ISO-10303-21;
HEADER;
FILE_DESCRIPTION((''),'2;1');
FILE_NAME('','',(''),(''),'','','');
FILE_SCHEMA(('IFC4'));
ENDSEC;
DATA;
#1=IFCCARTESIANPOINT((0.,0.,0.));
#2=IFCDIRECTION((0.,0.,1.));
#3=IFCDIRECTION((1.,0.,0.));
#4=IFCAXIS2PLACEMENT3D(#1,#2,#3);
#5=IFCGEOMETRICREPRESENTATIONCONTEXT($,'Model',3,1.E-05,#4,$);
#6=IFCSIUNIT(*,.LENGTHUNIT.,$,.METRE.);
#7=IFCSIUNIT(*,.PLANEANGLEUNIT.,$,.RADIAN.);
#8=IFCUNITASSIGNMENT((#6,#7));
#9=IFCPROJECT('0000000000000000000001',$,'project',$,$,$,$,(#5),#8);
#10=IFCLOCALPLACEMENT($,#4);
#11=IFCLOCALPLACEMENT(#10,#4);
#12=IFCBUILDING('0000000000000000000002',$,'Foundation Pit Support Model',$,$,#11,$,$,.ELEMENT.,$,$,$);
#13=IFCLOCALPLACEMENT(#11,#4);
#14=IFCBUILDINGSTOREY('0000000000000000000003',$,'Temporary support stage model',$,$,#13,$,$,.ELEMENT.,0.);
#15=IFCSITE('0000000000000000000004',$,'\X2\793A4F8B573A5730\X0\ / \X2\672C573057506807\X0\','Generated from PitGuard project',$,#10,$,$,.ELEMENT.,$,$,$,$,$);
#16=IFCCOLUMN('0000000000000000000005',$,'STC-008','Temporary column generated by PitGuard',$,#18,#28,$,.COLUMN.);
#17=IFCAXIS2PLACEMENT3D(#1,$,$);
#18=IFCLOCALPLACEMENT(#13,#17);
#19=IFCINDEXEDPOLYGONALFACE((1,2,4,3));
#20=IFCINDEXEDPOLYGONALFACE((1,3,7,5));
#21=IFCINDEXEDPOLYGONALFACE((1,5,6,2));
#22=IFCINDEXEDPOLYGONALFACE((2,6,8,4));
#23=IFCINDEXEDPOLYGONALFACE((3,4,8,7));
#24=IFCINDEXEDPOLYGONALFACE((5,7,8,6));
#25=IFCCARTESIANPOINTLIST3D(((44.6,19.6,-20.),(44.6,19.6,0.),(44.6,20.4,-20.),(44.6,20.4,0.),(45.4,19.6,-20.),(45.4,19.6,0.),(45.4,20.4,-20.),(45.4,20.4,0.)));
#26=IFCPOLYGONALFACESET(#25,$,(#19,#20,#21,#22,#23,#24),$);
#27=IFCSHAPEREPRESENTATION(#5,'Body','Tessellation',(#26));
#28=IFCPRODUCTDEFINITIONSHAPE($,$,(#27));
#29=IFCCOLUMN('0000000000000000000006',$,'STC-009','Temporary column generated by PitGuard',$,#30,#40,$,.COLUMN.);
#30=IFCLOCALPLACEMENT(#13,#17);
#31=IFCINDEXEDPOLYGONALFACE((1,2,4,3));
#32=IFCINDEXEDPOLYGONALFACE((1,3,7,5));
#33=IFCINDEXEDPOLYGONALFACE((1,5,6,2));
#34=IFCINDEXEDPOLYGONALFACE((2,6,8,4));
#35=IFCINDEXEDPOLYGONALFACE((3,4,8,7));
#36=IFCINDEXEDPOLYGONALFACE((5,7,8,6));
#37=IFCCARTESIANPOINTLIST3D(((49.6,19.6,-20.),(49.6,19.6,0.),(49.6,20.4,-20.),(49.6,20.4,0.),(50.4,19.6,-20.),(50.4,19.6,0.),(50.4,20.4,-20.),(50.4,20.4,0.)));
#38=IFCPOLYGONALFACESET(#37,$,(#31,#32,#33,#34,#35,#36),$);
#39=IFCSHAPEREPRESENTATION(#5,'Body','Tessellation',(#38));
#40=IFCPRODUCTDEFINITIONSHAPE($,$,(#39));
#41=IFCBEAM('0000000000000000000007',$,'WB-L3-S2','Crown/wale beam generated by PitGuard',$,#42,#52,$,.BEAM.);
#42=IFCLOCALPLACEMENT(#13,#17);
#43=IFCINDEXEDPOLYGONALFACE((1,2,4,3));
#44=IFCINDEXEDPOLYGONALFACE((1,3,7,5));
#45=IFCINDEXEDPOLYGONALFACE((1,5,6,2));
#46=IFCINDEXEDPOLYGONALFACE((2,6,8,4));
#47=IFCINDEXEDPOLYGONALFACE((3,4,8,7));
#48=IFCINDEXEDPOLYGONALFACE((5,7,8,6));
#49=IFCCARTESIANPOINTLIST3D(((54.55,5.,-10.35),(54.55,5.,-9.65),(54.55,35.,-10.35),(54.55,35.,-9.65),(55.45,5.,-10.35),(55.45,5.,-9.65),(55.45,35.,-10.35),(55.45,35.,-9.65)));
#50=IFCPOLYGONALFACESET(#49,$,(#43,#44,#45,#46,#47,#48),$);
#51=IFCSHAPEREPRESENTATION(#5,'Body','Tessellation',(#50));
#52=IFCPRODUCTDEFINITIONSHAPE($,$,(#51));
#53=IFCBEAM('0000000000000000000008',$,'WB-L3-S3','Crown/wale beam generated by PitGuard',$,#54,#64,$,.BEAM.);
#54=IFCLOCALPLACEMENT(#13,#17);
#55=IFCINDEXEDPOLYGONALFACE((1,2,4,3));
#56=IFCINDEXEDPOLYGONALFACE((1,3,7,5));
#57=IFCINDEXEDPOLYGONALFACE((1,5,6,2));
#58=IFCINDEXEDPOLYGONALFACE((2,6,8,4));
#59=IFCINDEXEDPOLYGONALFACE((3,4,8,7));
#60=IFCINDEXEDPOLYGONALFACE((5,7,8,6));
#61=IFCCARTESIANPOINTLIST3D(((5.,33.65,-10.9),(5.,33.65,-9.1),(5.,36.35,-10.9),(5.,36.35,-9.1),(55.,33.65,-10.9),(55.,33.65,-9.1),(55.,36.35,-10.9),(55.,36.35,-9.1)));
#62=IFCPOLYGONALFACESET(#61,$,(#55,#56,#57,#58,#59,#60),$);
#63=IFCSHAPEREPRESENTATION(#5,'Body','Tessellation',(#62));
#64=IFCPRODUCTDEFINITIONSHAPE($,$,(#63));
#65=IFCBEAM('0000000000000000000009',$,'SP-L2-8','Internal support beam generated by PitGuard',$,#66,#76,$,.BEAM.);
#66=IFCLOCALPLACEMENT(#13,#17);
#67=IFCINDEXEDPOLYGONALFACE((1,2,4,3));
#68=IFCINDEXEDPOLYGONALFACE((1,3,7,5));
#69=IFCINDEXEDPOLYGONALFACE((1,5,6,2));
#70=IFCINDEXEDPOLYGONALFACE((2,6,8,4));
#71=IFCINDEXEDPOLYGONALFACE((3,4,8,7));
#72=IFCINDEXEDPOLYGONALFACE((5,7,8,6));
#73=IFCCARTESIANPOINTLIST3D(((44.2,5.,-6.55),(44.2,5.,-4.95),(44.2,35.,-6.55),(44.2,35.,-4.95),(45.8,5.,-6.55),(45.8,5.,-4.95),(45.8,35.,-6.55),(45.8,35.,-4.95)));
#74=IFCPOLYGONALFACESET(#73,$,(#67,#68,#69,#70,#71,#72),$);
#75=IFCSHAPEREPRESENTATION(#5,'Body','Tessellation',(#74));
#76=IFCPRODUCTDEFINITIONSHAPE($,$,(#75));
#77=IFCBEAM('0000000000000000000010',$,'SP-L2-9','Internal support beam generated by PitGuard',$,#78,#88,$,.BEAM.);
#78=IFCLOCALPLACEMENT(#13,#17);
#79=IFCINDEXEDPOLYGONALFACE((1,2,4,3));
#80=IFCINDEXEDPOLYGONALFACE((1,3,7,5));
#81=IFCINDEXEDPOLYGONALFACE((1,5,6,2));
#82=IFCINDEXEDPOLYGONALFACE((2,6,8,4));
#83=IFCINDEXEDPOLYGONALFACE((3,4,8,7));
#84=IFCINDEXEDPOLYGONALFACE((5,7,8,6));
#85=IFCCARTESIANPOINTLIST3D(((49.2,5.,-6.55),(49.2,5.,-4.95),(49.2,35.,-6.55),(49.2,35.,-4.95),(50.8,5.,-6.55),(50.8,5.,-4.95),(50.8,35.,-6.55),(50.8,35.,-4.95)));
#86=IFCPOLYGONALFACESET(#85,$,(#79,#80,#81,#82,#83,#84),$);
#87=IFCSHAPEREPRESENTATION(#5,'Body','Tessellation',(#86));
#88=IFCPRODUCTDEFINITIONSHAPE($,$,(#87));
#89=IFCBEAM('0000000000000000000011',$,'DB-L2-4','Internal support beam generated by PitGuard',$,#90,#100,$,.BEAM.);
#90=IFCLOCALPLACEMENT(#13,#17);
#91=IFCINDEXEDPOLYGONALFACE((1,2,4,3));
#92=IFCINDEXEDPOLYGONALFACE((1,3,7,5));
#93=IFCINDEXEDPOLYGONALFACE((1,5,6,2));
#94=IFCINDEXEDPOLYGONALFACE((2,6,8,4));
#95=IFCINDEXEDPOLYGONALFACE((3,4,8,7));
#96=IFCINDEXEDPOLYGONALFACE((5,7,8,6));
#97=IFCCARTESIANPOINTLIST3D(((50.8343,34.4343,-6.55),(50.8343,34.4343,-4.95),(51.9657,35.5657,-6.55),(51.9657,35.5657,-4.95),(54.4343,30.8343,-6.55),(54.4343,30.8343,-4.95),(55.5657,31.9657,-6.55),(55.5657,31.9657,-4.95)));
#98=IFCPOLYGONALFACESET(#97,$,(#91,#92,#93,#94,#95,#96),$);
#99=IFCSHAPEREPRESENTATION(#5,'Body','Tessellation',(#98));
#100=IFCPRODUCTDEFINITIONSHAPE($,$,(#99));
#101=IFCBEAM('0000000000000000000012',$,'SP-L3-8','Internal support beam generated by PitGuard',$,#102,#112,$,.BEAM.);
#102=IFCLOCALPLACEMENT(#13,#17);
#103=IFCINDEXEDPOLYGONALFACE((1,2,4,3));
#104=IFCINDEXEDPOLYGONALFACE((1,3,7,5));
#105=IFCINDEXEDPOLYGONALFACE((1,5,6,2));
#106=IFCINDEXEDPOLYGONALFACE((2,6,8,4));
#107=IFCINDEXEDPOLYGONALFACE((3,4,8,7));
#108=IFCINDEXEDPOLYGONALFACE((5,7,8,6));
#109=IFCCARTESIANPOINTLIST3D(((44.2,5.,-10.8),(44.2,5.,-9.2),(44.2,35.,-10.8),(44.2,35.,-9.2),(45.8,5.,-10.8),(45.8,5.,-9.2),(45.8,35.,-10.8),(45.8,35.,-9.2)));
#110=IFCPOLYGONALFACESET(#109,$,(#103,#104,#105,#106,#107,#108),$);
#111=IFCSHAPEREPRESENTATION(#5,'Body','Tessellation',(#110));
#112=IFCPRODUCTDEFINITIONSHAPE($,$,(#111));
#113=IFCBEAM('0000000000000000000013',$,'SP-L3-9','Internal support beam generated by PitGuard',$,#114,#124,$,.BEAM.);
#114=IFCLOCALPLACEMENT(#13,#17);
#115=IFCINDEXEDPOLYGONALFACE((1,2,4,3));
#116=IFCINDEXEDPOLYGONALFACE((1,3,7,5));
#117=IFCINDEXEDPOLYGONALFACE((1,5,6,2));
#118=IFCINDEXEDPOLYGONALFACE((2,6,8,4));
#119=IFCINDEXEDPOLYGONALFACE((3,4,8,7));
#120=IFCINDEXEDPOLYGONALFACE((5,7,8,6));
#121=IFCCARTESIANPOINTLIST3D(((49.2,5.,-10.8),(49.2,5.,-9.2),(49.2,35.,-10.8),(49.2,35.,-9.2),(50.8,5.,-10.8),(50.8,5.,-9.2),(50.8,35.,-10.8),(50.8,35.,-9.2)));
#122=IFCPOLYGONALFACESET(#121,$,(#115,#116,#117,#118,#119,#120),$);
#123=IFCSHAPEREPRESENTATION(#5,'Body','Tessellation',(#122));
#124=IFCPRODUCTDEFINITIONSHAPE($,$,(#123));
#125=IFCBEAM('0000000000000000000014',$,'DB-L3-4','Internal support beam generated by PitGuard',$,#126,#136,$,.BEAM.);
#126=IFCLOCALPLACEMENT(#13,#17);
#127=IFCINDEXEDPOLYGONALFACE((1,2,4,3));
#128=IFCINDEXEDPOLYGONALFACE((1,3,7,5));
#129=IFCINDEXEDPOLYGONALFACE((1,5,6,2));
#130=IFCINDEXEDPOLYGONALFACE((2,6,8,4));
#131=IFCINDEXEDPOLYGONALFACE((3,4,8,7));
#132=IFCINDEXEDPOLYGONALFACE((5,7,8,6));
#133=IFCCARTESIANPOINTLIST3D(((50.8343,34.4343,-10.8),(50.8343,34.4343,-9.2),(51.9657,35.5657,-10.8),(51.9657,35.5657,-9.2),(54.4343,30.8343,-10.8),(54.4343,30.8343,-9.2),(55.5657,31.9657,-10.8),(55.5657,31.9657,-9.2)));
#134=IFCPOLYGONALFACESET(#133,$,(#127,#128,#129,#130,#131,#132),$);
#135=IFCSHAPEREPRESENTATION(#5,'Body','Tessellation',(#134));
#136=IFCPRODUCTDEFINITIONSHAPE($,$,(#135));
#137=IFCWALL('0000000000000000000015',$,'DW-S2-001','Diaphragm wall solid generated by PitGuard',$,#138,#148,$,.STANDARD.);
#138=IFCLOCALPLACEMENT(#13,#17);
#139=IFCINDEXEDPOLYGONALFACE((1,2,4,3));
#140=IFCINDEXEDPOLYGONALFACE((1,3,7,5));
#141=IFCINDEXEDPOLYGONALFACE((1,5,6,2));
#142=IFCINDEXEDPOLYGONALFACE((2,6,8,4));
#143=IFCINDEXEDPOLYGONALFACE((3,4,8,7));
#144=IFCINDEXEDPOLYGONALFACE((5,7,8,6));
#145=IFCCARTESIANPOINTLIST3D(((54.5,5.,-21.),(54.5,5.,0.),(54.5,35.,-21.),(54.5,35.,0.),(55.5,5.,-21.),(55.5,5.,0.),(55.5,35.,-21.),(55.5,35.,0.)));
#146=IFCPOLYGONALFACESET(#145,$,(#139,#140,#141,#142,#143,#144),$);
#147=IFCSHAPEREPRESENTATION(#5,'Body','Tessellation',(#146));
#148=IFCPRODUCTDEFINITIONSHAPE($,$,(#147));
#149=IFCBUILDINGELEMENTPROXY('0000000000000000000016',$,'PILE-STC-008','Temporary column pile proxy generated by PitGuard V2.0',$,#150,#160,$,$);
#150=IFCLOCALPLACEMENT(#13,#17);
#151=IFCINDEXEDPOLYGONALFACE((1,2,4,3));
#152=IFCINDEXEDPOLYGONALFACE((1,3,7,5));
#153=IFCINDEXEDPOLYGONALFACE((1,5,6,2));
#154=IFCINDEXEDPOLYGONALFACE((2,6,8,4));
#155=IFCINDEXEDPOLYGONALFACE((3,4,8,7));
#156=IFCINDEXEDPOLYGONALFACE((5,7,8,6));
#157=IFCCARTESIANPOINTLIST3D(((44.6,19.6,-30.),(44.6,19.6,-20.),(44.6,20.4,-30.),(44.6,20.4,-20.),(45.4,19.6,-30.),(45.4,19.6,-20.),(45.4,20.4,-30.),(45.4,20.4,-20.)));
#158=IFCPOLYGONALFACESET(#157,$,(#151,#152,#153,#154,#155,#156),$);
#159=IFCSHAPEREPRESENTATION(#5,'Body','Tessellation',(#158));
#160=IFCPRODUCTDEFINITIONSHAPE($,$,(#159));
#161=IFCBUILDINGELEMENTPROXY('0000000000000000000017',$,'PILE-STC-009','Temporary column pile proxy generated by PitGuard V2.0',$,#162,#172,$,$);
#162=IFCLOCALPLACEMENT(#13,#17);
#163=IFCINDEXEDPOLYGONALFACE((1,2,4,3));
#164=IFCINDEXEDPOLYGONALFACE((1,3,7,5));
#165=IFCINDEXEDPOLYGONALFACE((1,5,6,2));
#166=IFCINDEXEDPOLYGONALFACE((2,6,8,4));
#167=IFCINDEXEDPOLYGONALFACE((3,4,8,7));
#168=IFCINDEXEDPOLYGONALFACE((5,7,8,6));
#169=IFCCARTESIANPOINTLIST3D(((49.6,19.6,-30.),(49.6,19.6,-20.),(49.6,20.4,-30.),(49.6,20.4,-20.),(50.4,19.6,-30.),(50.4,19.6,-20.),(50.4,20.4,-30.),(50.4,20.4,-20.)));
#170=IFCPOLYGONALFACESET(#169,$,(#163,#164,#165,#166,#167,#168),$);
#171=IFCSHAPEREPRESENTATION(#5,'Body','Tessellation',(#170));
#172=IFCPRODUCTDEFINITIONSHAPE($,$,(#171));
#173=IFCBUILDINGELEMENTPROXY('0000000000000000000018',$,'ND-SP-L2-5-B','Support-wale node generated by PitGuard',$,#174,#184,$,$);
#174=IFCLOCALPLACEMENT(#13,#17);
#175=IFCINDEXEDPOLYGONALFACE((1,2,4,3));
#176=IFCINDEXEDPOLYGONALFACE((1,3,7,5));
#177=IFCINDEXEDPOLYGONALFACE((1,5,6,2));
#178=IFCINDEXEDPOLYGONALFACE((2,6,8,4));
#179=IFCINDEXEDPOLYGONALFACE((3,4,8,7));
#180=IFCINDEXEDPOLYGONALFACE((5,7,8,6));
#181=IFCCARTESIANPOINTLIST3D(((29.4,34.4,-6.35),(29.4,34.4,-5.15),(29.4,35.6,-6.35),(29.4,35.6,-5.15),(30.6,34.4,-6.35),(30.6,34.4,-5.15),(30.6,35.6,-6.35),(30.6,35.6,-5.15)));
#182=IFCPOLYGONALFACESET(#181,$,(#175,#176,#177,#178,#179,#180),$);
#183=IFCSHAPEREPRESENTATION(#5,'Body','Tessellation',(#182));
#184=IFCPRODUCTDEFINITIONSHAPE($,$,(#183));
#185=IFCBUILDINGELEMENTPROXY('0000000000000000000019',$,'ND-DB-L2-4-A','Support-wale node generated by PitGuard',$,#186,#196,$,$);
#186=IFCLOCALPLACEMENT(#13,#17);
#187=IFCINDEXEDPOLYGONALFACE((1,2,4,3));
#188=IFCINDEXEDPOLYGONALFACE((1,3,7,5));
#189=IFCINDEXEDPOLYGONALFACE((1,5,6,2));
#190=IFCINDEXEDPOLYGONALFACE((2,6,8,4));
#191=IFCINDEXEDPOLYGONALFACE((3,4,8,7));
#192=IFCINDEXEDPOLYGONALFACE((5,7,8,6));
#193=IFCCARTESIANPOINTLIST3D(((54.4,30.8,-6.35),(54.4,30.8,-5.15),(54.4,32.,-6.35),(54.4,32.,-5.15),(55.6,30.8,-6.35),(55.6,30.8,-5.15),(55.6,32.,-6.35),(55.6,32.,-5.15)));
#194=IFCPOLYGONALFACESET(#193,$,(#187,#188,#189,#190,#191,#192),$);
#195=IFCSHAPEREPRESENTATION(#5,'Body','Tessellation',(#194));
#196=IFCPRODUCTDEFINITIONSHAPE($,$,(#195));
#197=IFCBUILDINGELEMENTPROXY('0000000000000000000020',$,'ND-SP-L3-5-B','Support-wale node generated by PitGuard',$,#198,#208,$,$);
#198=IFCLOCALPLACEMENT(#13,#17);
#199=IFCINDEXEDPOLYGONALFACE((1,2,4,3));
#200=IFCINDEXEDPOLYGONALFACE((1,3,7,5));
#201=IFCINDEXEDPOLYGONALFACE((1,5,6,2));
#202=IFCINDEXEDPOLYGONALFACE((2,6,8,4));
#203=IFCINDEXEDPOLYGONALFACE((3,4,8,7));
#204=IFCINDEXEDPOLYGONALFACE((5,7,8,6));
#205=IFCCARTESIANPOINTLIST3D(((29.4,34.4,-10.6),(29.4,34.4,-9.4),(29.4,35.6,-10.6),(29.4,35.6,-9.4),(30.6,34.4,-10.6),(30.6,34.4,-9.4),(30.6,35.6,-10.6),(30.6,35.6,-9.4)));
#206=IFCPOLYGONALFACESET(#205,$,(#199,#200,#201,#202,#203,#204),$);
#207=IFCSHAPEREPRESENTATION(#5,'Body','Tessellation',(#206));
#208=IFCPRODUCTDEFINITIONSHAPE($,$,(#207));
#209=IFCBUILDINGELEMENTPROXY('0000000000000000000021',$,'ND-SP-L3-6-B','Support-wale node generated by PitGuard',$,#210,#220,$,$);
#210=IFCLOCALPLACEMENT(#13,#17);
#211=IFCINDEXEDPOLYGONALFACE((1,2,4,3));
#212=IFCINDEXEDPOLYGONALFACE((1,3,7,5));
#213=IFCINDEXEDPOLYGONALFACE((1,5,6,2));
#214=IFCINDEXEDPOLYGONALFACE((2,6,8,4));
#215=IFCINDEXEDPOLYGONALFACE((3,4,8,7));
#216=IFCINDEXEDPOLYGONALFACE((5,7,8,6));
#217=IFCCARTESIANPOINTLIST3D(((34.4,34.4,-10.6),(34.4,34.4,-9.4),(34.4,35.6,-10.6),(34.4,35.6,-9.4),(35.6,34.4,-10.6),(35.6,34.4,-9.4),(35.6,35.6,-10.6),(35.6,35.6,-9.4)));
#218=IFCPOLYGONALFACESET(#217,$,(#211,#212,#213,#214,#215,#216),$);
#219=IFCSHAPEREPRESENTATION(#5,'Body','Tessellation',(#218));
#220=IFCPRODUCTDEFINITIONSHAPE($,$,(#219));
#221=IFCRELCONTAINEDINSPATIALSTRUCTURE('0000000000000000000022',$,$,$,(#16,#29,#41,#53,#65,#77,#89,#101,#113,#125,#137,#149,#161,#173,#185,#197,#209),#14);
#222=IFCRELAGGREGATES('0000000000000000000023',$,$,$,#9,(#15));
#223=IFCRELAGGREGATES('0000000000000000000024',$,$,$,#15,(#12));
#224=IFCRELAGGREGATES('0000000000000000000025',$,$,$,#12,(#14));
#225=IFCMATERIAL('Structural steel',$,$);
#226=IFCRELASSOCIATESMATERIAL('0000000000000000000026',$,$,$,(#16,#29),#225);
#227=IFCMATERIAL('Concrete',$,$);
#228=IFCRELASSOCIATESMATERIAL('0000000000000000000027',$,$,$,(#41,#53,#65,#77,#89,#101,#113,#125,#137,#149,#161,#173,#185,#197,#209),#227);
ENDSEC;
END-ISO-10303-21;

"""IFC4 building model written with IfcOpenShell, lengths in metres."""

from ifc_helpers import new_model, si_unit, frame, origin_with_axes, origin_2d, place, context, project, spatial, rectangle, extrude, material, element, save


model = new_model("IFC4")

# Units and contexts
model_context = context("Model", 3, precision=1e-05, world=origin_with_axes())
ifc_project = project(units=[si_unit("LENGTHUNIT", "METRE"), si_unit("PLANEANGLEUNIT", "RADIAN")], contexts=[model_context])

# Site, building, storey
site_placement = place(None, origin_with_axes())
site = spatial("IfcSite", under=ifc_project, at=site_placement, Name="示例场地 / 本地坐标", Description="Generated from PitGuard project", CompositionType="ELEMENT")
building_placement = place(site_placement, origin_with_axes())
building = spatial("IfcBuilding", under=site, at=building_placement, Name="Foundation Pit Support Model", CompositionType="ELEMENT")
storey_placement = place(building_placement, origin_with_axes())
storey = spatial("IfcBuildingStorey", under=building, at=storey_placement, Name="Temporary support stage model", CompositionType="ELEMENT", Elevation=0.0)

# Columns
ifc_material_1 = material(Name="Structural steel")
for number, where, z_axis, x_axis, name in (
    (1, (45.0, 20.0, -20.0), (0.0, 0.0, 1.0), (1.0, 0.0, 0.0), "STC-008"),
    (2, (50.0, 20.0, -20.0), (0.0, 0.0, 1.0), (1.0, 0.0, 0.0), "STC-009"),
):
    element("IfcColumn", number, at=place(storey_placement, frame(where, z_axis=z_axis, x_axis=x_axis)), inside=storey, material=ifc_material_1, Name=name, Description="Temporary column generated by PitGuard", PredefinedType="COLUMN", context=model_context, shape_type="SweptSolid", body=[
        extrude(rectangle(XDim=0.8, YDim=0.8, at=origin_2d()), origin_with_axes(), (0.0, 0.0, 1.0), 20.0),
    ])

# Beams
ifc_material_2 = material(Name="Concrete")
beam_1_placement = place(storey_placement, frame((55.0, 20.0, -10.35), z_axis=(0.0, 0.0, 1.0), x_axis=(0.0, 1.0, 0.0)))
element("IfcBeam", 3, at=beam_1_placement, inside=storey, material=ifc_material_2, Name="WB-L3-S2", Description="Crown/wale beam generated by PitGuard", PredefinedType="BEAM", context=model_context, shape_type="SweptSolid", body=[
    extrude(rectangle(XDim=30.0, YDim=0.9, at=origin_2d()), origin_with_axes(), (0.0, 0.0, 1.0), 0.7),
])
beam_2_placement = place(storey_placement, frame((30.0, 35.0, -10.9), z_axis=(0.0, 0.0, 1.0), x_axis=(-1.0, 0.0, 0.0)))
element("IfcBeam", 4, at=beam_2_placement, inside=storey, material=ifc_material_2, Name="WB-L3-S3", Description="Crown/wale beam generated by PitGuard", PredefinedType="BEAM", context=model_context, shape_type="SweptSolid", body=[
    extrude(rectangle(XDim=50.0, YDim=2.7, at=origin_2d()), origin_with_axes(), (0.0, 0.0, 1.0), 1.8),
])
for number, where, z_axis, x_axis, name in (
    (5, (45.0, 20.0, -6.55), (0.0, 0.0, 1.0), (0.0, 1.0, 0.0), "SP-L2-8"),
    (6, (50.0, 20.0, -6.55), (0.0, 0.0, 1.0), (0.0, 1.0, 0.0), "SP-L2-9"),
):
    element("IfcBeam", number, at=place(storey_placement, frame(where, z_axis=z_axis, x_axis=x_axis)), inside=storey, material=ifc_material_2, Name=name, Description="Internal support beam generated by PitGuard", PredefinedType="BEAM", context=model_context, shape_type="SweptSolid", body=[
        extrude(rectangle(XDim=30.0, YDim=1.6, at=origin_2d()), origin_with_axes(), (0.0, 0.0, 1.0), 1.6),
    ])
beam_3_placement = place(storey_placement, frame((53.2, 33.2, -6.55), z_axis=(0.0, 0.0, 1.0), x_axis=(-0.707107, 0.707107, 0.0)))
element("IfcBeam", 7, at=beam_3_placement, inside=storey, material=ifc_material_2, Name="DB-L2-4", Description="Internal support beam generated by PitGuard", PredefinedType="BEAM", context=model_context, shape_type="SweptSolid", body=[
    extrude(rectangle(XDim=5.0912, YDim=1.6, at=origin_2d()), origin_with_axes(), (0.0, 0.0, 1.0), 1.6),
])
for number, where, z_axis, x_axis, name in (
    (8, (45.0, 20.0, -10.8), (0.0, 0.0, 1.0), (0.0, 1.0, 0.0), "SP-L3-8"),
    (9, (50.0, 20.0, -10.8), (0.0, 0.0, 1.0), (0.0, 1.0, 0.0), "SP-L3-9"),
):
    element("IfcBeam", number, at=place(storey_placement, frame(where, z_axis=z_axis, x_axis=x_axis)), inside=storey, material=ifc_material_2, Name=name, Description="Internal support beam generated by PitGuard", PredefinedType="BEAM", context=model_context, shape_type="SweptSolid", body=[
        extrude(rectangle(XDim=30.0, YDim=1.6, at=origin_2d()), origin_with_axes(), (0.0, 0.0, 1.0), 1.6),
    ])
beam_4_placement = place(storey_placement, frame((53.2, 33.2, -10.8), z_axis=(0.0, 0.0, 1.0), x_axis=(-0.707107, 0.707107, 0.0)))
element("IfcBeam", 10, at=beam_4_placement, inside=storey, material=ifc_material_2, Name="DB-L3-4", Description="Internal support beam generated by PitGuard", PredefinedType="BEAM", context=model_context, shape_type="SweptSolid", body=[
    extrude(rectangle(XDim=5.0912, YDim=1.6, at=origin_2d()), origin_with_axes(), (0.0, 0.0, 1.0), 1.6),
])

# Wall
wall_placement = place(storey_placement, frame((55.0, 20.0, -21.0), z_axis=(0.0, 0.0, 1.0), x_axis=(0.0, 1.0, 0.0)))
element("IfcWall", 11, at=wall_placement, inside=storey, material=ifc_material_2, Name="DW-S2-001", Description="Diaphragm wall solid generated by PitGuard", PredefinedType="STANDARD", context=model_context, shape_type="SweptSolid", body=[
    extrude(rectangle(XDim=30.0, YDim=1.0, at=origin_2d()), origin_with_axes(), (0.0, 0.0, 1.0), 21.0),
])

# Building element proxies
for number, where, z_axis, x_axis, name in (
    (12, (45.0, 20.0, -30.0), (0.0, 0.0, 1.0), (1.0, 0.0, 0.0), "PILE-STC-008"),
    (13, (50.0, 20.0, -30.0), (0.0, 0.0, 1.0), (1.0, 0.0, 0.0), "PILE-STC-009"),
):
    element("IfcBuildingElementProxy", number, at=place(storey_placement, frame(where, z_axis=z_axis, x_axis=x_axis)), inside=storey, material=ifc_material_2, Name=name, Description="Temporary column pile proxy generated by PitGuard V2.0", context=model_context, shape_type="SweptSolid", body=[
        extrude(rectangle(XDim=0.8, YDim=0.8, at=origin_2d()), origin_with_axes(), (0.0, 0.0, 1.0), 10.0),
    ])
for number, where, z_axis, x_axis, name in (
    (14, (30.0, 35.0, -6.35), (0.0, 0.0, 1.0), (1.0, 0.0, 0.0), "ND-SP-L2-5-B"),
    (15, (55.0, 31.4, -6.35), (0.0, 0.0, 1.0), (1.0, 0.0, 0.0), "ND-DB-L2-4-A"),
    (16, (30.0, 35.0, -10.6), (0.0, 0.0, 1.0), (1.0, 0.0, 0.0), "ND-SP-L3-5-B"),
    (17, (35.0, 35.0, -10.6), (0.0, 0.0, 1.0), (1.0, 0.0, 0.0), "ND-SP-L3-6-B"),
):
    element("IfcBuildingElementProxy", number, at=place(storey_placement, frame(where, z_axis=z_axis, x_axis=x_axis)), inside=storey, material=ifc_material_2, Name=name, Description="Support-wale node generated by PitGuard", context=model_context, shape_type="SweptSolid", body=[
        extrude(rectangle(XDim=1.2, YDim=1.2, at=origin_2d()), origin_with_axes(), (0.0, 0.0, 1.0), 1.2),
    ])

save(model, "model.ifc")
